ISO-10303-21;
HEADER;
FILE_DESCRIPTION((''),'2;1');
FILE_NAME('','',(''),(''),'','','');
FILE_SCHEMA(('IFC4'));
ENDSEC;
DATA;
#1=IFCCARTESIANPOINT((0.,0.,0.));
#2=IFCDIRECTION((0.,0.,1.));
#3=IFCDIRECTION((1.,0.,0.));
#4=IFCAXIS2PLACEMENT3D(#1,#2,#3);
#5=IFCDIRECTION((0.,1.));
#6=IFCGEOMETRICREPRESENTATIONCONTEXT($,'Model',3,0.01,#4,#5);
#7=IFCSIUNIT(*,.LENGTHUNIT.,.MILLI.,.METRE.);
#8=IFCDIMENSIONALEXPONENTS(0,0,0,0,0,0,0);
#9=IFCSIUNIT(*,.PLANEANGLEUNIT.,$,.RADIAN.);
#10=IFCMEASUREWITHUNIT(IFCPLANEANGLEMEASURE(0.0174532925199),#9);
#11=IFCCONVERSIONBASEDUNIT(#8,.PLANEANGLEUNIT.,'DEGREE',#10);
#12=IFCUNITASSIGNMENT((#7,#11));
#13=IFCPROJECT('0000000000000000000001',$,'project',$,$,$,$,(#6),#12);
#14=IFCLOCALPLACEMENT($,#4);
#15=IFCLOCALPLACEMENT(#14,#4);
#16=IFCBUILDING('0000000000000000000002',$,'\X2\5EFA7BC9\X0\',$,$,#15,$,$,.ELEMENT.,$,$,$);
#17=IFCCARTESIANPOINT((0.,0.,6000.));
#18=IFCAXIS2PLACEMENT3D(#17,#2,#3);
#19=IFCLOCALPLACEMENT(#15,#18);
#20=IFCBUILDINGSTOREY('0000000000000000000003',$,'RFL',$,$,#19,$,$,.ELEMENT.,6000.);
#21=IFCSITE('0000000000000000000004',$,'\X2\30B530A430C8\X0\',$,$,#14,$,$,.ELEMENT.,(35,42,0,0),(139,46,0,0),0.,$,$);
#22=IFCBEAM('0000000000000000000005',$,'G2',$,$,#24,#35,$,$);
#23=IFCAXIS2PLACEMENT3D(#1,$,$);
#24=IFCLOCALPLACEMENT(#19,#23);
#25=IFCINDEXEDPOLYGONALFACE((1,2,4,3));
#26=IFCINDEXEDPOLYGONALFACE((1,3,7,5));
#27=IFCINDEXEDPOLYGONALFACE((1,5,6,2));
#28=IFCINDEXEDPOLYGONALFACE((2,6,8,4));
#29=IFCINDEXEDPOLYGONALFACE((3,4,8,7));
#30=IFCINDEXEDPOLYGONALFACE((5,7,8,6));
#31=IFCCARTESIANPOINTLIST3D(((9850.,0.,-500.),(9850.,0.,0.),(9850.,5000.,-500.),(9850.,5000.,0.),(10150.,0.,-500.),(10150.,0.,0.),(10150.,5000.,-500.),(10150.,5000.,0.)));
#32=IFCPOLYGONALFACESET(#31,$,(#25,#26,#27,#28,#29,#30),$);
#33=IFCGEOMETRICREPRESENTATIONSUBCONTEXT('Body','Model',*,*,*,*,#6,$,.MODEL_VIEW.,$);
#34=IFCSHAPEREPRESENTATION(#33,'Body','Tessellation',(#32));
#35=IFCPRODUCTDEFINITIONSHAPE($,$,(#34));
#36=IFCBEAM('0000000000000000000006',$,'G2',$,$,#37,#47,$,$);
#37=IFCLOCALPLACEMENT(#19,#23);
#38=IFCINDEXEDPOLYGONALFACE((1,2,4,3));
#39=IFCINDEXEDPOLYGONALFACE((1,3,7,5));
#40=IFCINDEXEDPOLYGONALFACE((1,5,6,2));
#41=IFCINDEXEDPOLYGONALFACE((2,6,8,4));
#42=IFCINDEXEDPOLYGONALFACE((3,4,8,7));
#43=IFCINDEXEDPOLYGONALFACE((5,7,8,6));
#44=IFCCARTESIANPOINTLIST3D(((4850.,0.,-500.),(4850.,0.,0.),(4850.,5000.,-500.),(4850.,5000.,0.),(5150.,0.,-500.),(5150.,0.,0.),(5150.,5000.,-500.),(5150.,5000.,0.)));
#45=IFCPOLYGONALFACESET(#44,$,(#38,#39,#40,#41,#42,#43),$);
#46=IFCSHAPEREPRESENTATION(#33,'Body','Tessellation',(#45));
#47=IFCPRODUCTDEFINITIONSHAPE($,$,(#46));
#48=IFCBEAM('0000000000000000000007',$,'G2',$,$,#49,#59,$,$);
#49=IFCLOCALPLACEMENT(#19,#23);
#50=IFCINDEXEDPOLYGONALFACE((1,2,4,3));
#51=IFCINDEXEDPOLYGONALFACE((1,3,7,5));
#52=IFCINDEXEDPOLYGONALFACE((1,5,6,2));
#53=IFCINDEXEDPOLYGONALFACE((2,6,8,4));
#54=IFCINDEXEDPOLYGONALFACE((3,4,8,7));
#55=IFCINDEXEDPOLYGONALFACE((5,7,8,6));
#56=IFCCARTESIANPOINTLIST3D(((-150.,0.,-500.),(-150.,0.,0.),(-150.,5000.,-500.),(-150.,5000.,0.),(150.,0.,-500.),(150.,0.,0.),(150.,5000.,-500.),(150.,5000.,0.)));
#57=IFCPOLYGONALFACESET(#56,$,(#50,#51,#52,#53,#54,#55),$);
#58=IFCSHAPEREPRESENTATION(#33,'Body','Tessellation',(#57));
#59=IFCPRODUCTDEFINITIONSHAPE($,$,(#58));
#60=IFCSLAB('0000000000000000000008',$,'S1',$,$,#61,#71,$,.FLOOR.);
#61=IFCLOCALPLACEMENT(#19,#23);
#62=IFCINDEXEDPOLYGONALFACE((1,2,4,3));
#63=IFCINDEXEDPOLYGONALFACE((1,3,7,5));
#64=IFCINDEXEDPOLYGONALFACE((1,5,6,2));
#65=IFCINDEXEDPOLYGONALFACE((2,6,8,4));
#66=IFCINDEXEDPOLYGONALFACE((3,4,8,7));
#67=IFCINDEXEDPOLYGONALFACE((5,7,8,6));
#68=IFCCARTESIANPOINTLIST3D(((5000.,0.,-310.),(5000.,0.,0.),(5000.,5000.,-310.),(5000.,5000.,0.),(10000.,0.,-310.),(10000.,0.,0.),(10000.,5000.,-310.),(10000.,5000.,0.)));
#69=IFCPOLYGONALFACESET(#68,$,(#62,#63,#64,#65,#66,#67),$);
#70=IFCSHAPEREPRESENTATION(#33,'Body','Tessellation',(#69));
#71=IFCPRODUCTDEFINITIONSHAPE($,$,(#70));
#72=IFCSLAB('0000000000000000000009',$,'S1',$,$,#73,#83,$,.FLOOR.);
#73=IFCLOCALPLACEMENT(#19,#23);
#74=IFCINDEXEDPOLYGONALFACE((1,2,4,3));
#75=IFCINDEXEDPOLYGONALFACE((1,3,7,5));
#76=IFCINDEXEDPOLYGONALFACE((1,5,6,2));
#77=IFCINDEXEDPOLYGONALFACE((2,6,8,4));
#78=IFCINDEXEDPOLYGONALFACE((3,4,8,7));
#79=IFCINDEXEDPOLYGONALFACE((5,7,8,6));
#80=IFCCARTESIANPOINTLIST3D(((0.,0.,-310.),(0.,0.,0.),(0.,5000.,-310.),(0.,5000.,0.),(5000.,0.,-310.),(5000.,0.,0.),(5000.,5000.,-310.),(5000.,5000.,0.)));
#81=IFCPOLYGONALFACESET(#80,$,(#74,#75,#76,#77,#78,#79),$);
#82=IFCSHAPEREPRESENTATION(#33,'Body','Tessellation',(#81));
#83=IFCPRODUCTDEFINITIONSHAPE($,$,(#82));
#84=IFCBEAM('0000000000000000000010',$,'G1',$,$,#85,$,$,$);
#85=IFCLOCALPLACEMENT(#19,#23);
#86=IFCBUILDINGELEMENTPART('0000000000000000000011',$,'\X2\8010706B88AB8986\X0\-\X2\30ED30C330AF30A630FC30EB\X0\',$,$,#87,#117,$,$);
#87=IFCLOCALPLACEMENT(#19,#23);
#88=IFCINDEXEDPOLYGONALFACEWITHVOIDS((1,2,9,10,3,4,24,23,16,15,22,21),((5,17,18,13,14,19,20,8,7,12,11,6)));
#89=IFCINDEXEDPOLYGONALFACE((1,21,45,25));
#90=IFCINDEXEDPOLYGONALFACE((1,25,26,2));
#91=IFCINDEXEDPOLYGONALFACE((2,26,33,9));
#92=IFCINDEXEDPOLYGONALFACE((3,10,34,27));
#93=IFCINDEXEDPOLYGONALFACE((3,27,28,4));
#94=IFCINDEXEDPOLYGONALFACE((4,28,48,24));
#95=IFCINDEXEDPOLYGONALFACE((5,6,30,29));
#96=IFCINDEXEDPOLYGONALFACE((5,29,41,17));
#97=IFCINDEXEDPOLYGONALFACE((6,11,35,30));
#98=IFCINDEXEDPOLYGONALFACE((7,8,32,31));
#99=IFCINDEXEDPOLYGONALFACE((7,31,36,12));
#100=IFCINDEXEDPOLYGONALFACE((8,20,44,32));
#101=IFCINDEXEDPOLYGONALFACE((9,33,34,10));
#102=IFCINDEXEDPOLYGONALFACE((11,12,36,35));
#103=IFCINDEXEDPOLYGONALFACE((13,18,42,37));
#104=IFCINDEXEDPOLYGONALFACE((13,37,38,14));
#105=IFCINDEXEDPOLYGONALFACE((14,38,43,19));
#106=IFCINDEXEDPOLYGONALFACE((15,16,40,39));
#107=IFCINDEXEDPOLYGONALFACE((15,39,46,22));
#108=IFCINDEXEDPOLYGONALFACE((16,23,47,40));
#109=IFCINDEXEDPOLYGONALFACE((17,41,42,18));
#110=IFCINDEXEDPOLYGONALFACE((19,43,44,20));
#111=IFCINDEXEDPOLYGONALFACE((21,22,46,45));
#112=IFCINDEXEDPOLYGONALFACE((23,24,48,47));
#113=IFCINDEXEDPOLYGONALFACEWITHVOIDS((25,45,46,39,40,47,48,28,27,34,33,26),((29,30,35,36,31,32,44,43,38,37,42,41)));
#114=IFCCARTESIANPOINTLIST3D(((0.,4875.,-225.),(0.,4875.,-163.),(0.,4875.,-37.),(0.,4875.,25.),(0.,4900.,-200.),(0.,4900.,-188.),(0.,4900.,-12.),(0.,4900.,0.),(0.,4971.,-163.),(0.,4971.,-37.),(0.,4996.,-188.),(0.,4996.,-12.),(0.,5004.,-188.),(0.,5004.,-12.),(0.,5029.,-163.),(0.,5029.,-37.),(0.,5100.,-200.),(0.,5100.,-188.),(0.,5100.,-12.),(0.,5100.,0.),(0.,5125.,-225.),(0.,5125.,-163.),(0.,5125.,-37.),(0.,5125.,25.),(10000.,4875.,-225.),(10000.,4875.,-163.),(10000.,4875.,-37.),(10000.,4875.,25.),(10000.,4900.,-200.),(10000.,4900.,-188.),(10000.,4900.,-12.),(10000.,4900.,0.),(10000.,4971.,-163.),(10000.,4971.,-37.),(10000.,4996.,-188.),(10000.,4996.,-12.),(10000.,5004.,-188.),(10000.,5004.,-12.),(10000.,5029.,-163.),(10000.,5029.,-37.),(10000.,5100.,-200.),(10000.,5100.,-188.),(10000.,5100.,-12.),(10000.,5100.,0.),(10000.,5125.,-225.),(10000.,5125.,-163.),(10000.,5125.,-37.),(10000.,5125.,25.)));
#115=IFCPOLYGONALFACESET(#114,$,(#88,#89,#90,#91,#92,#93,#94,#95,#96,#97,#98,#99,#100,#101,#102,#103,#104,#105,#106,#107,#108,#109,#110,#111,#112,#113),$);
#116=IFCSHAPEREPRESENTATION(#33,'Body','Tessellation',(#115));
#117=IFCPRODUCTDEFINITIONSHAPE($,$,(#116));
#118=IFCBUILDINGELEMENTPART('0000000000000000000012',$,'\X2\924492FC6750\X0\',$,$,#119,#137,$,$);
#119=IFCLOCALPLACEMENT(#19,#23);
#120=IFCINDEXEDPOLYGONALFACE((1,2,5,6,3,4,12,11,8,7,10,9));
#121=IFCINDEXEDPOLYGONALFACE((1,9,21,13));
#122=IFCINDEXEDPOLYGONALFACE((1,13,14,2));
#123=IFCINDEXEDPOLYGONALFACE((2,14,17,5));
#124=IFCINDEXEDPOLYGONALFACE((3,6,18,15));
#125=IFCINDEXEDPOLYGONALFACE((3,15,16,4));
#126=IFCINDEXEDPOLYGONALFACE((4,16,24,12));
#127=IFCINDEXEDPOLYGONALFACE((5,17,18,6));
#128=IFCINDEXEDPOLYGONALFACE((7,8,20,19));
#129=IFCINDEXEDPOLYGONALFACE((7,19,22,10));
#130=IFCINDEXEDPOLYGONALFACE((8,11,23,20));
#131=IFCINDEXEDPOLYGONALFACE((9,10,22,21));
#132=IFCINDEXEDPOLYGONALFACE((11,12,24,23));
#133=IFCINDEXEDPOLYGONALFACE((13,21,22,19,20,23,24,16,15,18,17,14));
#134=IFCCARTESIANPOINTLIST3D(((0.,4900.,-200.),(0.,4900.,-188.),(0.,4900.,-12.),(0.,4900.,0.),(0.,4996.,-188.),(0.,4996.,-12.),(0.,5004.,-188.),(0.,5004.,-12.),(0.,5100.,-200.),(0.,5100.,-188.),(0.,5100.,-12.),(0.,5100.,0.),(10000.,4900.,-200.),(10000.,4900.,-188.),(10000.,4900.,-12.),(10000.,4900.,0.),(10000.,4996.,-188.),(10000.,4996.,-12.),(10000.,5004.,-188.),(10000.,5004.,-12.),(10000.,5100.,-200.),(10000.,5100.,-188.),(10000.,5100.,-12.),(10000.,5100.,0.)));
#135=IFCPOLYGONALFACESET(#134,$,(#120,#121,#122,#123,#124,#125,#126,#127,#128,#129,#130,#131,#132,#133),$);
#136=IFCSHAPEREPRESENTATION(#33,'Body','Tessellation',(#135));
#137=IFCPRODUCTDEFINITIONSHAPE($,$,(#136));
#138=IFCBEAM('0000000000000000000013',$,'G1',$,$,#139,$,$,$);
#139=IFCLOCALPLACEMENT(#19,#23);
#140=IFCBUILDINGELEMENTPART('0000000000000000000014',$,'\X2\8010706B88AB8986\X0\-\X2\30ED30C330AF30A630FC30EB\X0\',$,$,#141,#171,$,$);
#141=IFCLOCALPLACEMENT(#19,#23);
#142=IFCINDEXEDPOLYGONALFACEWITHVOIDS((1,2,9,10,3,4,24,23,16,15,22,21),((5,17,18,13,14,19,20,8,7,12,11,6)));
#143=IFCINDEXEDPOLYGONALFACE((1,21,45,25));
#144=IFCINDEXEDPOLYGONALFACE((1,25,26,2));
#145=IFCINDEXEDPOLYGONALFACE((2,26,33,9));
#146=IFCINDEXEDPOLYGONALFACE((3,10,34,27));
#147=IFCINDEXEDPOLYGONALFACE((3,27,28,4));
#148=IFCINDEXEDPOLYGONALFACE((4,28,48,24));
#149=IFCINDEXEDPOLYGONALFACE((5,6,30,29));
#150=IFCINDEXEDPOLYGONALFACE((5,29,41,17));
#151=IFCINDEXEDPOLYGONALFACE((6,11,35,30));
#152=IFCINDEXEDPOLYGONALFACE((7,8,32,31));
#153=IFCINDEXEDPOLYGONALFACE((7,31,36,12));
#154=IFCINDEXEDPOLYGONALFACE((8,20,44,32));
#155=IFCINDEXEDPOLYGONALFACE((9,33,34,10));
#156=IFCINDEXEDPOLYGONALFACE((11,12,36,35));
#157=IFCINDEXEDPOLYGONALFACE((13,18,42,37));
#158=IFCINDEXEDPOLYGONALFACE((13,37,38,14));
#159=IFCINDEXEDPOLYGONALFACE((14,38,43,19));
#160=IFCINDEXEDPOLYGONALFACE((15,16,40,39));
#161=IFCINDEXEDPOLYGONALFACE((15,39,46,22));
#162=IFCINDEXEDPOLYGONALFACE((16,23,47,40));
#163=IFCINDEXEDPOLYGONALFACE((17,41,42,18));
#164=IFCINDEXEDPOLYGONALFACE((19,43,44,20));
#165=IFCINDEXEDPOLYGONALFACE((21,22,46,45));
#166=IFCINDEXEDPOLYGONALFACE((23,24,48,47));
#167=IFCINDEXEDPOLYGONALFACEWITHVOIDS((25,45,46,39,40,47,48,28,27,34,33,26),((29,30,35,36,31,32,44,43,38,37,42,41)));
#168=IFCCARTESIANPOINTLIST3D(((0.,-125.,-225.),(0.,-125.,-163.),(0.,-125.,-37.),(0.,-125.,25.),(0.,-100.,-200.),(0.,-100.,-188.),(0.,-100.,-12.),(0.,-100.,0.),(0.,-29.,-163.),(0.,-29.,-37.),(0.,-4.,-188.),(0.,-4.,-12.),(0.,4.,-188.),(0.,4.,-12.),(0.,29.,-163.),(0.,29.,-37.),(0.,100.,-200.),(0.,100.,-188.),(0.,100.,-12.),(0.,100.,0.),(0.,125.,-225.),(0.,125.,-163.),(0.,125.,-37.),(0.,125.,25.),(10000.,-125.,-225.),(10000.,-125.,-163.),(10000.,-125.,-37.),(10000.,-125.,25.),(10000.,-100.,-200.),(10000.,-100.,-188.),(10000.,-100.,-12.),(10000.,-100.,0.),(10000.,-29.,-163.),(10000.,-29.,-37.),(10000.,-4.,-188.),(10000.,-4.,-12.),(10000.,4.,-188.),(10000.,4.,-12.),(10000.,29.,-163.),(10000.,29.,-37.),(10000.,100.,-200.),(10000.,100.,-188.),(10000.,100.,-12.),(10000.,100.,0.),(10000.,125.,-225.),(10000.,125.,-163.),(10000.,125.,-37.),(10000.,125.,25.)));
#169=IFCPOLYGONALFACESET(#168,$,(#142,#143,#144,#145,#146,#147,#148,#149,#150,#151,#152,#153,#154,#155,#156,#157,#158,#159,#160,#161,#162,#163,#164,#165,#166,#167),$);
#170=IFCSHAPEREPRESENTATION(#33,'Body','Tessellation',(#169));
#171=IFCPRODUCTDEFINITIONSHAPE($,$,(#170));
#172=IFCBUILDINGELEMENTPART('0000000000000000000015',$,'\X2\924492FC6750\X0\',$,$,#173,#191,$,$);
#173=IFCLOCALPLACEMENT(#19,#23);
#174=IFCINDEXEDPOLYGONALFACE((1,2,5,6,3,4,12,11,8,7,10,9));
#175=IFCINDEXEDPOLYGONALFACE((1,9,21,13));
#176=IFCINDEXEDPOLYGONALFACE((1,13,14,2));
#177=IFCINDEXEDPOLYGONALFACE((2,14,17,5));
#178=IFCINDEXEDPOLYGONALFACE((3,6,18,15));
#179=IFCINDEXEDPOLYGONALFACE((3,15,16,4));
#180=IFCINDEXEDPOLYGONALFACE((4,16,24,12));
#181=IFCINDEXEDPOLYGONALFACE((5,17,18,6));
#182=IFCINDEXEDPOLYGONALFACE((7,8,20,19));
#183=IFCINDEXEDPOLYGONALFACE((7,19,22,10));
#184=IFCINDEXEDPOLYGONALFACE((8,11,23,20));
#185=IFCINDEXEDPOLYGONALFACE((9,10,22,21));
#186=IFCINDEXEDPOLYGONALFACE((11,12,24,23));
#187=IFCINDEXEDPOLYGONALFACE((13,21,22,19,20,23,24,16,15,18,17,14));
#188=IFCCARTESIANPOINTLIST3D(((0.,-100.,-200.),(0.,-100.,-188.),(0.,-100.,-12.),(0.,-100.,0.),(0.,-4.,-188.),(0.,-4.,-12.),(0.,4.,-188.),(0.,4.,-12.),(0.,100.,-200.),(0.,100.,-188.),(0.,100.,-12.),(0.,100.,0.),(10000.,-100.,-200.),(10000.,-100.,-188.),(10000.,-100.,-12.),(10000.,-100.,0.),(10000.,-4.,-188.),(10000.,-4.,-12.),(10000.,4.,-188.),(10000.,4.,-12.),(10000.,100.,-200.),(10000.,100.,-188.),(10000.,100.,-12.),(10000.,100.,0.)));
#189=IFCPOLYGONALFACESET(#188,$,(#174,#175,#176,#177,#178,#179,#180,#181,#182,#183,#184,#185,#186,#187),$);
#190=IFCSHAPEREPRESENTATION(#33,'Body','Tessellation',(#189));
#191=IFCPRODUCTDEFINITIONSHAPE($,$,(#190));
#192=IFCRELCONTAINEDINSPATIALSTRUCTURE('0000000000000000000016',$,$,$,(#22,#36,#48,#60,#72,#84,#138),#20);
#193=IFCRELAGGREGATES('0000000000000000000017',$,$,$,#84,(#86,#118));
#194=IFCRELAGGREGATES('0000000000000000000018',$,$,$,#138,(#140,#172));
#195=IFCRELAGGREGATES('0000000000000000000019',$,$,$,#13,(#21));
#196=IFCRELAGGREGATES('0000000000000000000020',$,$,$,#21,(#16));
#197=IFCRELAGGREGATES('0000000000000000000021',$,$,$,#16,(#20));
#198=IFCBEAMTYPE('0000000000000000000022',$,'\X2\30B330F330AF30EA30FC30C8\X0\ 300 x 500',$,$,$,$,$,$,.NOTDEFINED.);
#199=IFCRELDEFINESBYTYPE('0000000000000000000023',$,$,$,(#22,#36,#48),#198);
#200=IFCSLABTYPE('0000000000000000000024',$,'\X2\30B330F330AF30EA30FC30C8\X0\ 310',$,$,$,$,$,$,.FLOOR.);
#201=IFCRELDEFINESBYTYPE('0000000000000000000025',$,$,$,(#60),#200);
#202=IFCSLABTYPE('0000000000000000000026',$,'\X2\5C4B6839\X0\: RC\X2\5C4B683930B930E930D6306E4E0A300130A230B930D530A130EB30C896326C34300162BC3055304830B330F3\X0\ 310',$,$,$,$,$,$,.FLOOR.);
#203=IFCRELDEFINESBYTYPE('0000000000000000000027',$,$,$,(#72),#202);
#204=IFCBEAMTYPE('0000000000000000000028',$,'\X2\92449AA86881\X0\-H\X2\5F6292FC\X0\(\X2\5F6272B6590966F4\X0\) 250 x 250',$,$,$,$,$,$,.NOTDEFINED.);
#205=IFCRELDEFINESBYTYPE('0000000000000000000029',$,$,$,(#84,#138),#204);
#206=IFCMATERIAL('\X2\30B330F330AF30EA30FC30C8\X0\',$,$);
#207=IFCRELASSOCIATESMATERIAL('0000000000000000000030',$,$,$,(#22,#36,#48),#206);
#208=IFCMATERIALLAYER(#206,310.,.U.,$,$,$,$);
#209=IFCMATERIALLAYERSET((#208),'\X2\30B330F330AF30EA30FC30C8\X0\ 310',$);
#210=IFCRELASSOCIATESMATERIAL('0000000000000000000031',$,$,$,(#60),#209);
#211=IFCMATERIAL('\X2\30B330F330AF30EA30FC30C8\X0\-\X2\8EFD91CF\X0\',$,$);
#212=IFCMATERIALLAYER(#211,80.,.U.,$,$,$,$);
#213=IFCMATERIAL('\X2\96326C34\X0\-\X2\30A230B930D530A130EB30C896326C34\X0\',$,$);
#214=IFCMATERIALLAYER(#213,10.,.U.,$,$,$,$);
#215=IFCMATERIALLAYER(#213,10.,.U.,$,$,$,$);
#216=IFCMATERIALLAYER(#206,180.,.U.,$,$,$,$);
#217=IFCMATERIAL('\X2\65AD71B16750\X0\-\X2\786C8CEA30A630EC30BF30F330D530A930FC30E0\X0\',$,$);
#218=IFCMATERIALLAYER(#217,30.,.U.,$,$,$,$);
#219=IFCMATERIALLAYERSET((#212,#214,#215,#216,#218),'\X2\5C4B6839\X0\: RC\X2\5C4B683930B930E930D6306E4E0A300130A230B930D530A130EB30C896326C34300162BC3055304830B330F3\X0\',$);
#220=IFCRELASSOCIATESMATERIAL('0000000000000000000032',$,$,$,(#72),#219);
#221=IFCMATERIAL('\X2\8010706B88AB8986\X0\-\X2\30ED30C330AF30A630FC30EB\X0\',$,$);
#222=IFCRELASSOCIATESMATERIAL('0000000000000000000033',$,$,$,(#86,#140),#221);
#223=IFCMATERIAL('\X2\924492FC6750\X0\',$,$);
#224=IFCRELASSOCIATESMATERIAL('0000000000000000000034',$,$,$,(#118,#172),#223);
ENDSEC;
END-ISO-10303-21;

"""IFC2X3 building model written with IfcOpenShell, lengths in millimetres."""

from ifc_helpers import new_model, entity, si_unit, converted_unit, direction, frame, frame_2d, origin_with_axes, place, context, subcontext, project, spatial, polyline, rectangle, outline, extrude, material, layer, layer_set, layer_usage, type_object, element, aggregate, save


model = new_model("IFC2X3")

# Units and contexts
model_context = context("Model", 3, precision=0.01, world=origin_with_axes(), true_north=direction((0.0, 1.0)))
body_context = subcontext(model_context, "Body", "Model", "MODEL_VIEW")
ifc_project = project(units=[si_unit("LENGTHUNIT", "METRE", prefix="MILLI"), converted_unit("PLANEANGLEUNIT", "DEGREE", entity("IfcPlaneAngleMeasure", 0.0174532925199), si_unit("PLANEANGLEUNIT", "RADIAN"), dimensions=[0, 0, 0, 0, 0, 0, 0])], contexts=[model_context])

# Site, building, storey
site_placement = place(None, origin_with_axes())
site = spatial("IfcSite", under=ifc_project, at=site_placement, Name="サイト", CompositionType="ELEMENT", RefLatitude=(35, 42, 0, 0), RefLongitude=(139, 46, 0, 0), RefElevation=0.0)
building_placement = place(site_placement, origin_with_axes())
building = spatial("IfcBuilding", under=site, at=building_placement, Name="建築", CompositionType="ELEMENT")
storey_placement = place(building_placement, frame((0.0, 0.0, 6000.0), z_axis=(0.0, 0.0, 1.0), x_axis=(1.0, 0.0, 0.0)))
storey = spatial("IfcBuildingStorey", under=building, at=storey_placement, Name="RFL", CompositionType="ELEMENT", Elevation=6000.0)

# Beams
ifc_material_1 = material(Name="コンクリート")
beam_type_1 = type_object("IfcBeamType", Name="コンクリート 300 x 500", PredefinedType="NOTDEFINED")
for number, where, z_axis, x_axis, name in (
    (1, (10000.0, 5000.0, 0.0), (0.0, 0.0, 1.0), (-1.0, 0.0, 0.0), "G2"),
    (2, (5000.0, 5000.0, 0.0), (0.0, 0.0, 1.0), (-1.0, 0.0, 0.0), "G2"),
    (3, (0.0, 5000.0, 0.0), (0.0, 0.0, 1.0), (-1.0, 0.0, 0.0), "G2"),
):
    element("IfcBeam", number, at=place(storey_placement, frame(where, z_axis=z_axis, x_axis=x_axis)), inside=storey, type_object=beam_type_1, material=ifc_material_1, Name=name, context=body_context, shape_type="SweptSolid", body=[
        extrude(rectangle(XDim=500.0, YDim=300.0, at=frame_2d((-250.0, 0.0), x_axis=(1.0, 0.0))), frame((0.0, 0.0, 0.0), z_axis=(0.0, 1.0, 0.0), x_axis=(0.0, 0.0, 1.0)), (0.0, 0.0, 1.0), 5000.0),
    ])

# Slabs
ifc_layer_1 = layer(ifc_material_1, 310.0, ventilated="UNKNOWN")
ifc_layer_set_1 = layer_set([ifc_layer_1], Name="コンクリート 310")
ifc_layer_usage_1 = layer_usage(ifc_layer_set_1, "AXIS3", "NEGATIVE", 310.0)
slab_type_1 = type_object("IfcSlabType", Name="コンクリート 310", PredefinedType="FLOOR")
slab_1_placement = place(storey_placement, frame((5000.0, 0.0, 0.0), z_axis=(0.0, 0.0, 1.0), x_axis=(1.0, 0.0, 0.0)))
element("IfcSlab", 4, at=slab_1_placement, inside=storey, type_object=slab_type_1, material=ifc_layer_usage_1, Name="S1", PredefinedType="FLOOR", context=body_context, shape_type="SweptSolid", body=[
    extrude(outline(polyline([(0.0, 0.0), (5000.0, 0.0), (5000.0, 5000.0), (0.0, 5000.0), (0.0, 0.0)])), frame((0.0, 0.0, -310.0), z_axis=(0.0, 0.0, 1.0), x_axis=(1.0, 0.0, 0.0)), (0.0, 0.0, 1.0), 310.0),
])
ifc_material_2 = material(Name="コンクリート-軽量")
ifc_layer_2 = layer(ifc_material_2, 80.0, ventilated="UNKNOWN")
ifc_material_3 = material(Name="防水-アスファルト防水")
ifc_layer_3 = layer(ifc_material_3, 10.0, ventilated="UNKNOWN")
ifc_layer_4 = layer(ifc_material_3, 10.0, ventilated="UNKNOWN")
ifc_layer_5 = layer(ifc_material_1, 180.0, ventilated="UNKNOWN")
ifc_material_4 = material(Name="断熱材-硬質ウレタンフォーム")
ifc_layer_6 = layer(ifc_material_4, 30.0, ventilated="UNKNOWN")
ifc_layer_set_2 = layer_set([ifc_layer_2, ifc_layer_3, ifc_layer_4, ifc_layer_5, ifc_layer_6], Name="屋根: RC屋根スラブの上、アスファルト防水、押さえコン")
ifc_layer_usage_2 = layer_usage(ifc_layer_set_2, "AXIS3", "NEGATIVE", 310.0)
slab_type_2 = type_object("IfcSlabType", Name="屋根: RC屋根スラブの上、アスファルト防水、押さえコン 310", PredefinedType="FLOOR")
slab_2_placement = place(storey_placement, origin_with_axes())
element("IfcSlab", 5, at=slab_2_placement, inside=storey, type_object=slab_type_2, material=ifc_layer_usage_2, Name="S1", PredefinedType="FLOOR", context=body_context, shape_type="SweptSolid", body=[
    extrude(outline(polyline([(0.0, 0.0), (5000.0, 0.0), (5000.0, 5000.0), (0.0, 5000.0), (0.0, 0.0)])), frame((0.0, 0.0, -310.0), z_axis=(0.0, 0.0, 1.0), x_axis=(1.0, 0.0, 0.0)), (0.0, 0.0, 1.0), 310.0),
])

# Beams, building element parts
beam_type_2 = type_object("IfcBeamType", Name="鉄骨梁-H形鋼(形状変更) 250 x 250", PredefinedType="NOTDEFINED")
beam_1_placement = place(storey_placement, frame((0.0, 5000.0, 0.0), z_axis=(0.0, 0.0, 1.0), x_axis=(0.0, -1.0, 0.0)))
beam_1 = element("IfcBeam", 6, at=beam_1_placement, inside=storey, type_object=beam_type_2, Name="G1")
ifc_material_5 = material(Name="耐火被覆-ロックウール")
building_element_part_1_placement = place(beam_1_placement, origin_with_axes())
building_element_part_1 = element("IfcBuildingElementPart", 7, at=building_element_part_1_placement, material=ifc_material_5, Name="耐火被覆-ロックウール", context=body_context, shape_type="SweptSolid", body=[
    extrude(outline(polyline([(-125.0, 25.0), (-125.0, -37.0), (-29.0, -37.0), (-29.0, -163.0), (-125.0, -163.0), (-125.0, -225.0), (125.0, -225.0), (125.0, -163.0), (29.0, -163.0), (29.0, -37.0), (125.0, -37.0), (125.0, 25.0), (-125.0, 25.0)]), holes=[polyline([(-100.0, -188.0), (-4.0, -188.0), (-4.0, -12.0), (-100.0, -12.0), (-100.0, 0.0), (100.0, 0.0), (100.0, -12.0), (4.0, -12.0), (4.0, -188.0), (100.0, -188.0), (100.0, -200.0), (-100.0, -200.0), (-100.0, -188.0)])]), frame((0.0, 10000.0, 0.0), z_axis=(0.0, -1.0, 0.0), x_axis=(1.0, 0.0, 0.0)), (0.0, 0.0, 1.0), 10000.0),
])
ifc_material_6 = material(Name="鉄鋼材")
building_element_part_2_placement = place(beam_1_placement, origin_with_axes())
building_element_part_2 = element("IfcBuildingElementPart", 8, at=building_element_part_2_placement, material=ifc_material_6, Name="鉄鋼材", context=body_context, shape_type="SweptSolid", body=[
    extrude(outline(polyline([(-100.0, 0.0), (-100.0, -12.0), (-4.0, -12.0), (-4.0, -188.0), (-100.0, -188.0), (-100.0, -200.0), (100.0, -200.0), (100.0, -188.0), (4.0, -188.0), (4.0, -12.0), (100.0, -12.0), (100.0, 0.0), (-100.0, 0.0)])), frame((0.0, 10000.0, 0.0), z_axis=(0.0, -1.0, 0.0), x_axis=(1.0, 0.0, 0.0)), (0.0, 0.0, 1.0), 10000.0),
])
aggregate(beam_1, [building_element_part_1, building_element_part_2])
beam_2_placement = place(storey_placement, frame((0.0, 0.0, 0.0), z_axis=(0.0, 0.0, 1.0), x_axis=(0.0, -1.0, 0.0)))
beam_2 = element("IfcBeam", 9, at=beam_2_placement, inside=storey, type_object=beam_type_2, Name="G1")
building_element_part_3_placement = place(beam_2_placement, origin_with_axes())
building_element_part_3 = element("IfcBuildingElementPart", 10, at=building_element_part_3_placement, material=ifc_material_5, Name="耐火被覆-ロックウール", context=body_context, shape_type="SweptSolid", body=[
    extrude(outline(polyline([(-125.0, 25.0), (-125.0, -37.0), (-29.0, -37.0), (-29.0, -163.0), (-125.0, -163.0), (-125.0, -225.0), (125.0, -225.0), (125.0, -163.0), (29.0, -163.0), (29.0, -37.0), (125.0, -37.0), (125.0, 25.0), (-125.0, 25.0)]), holes=[polyline([(-100.0, -188.0), (-4.0, -188.0), (-4.0, -12.0), (-100.0, -12.0), (-100.0, 0.0), (100.0, 0.0), (100.0, -12.0), (4.0, -12.0), (4.0, -188.0), (100.0, -188.0), (100.0, -200.0), (-100.0, -200.0), (-100.0, -188.0)])]), frame((0.0, 10000.0, 0.0), z_axis=(0.0, -1.0, 0.0), x_axis=(1.0, 0.0, 0.0)), (0.0, 0.0, 1.0), 10000.0),
])
building_element_part_4_placement = place(beam_2_placement, origin_with_axes())
building_element_part_4 = element("IfcBuildingElementPart", 11, at=building_element_part_4_placement, material=ifc_material_6, Name="鉄鋼材", context=body_context, shape_type="SweptSolid", body=[
    extrude(outline(polyline([(-100.0, 0.0), (-100.0, -12.0), (-4.0, -12.0), (-4.0, -188.0), (-100.0, -188.0), (-100.0, -200.0), (100.0, -200.0), (100.0, -188.0), (4.0, -188.0), (4.0, -12.0), (100.0, -12.0), (100.0, 0.0), (-100.0, 0.0)])), frame((0.0, 10000.0, 0.0), z_axis=(0.0, -1.0, 0.0), x_axis=(1.0, 0.0, 0.0)), (0.0, 0.0, 1.0), 10000.0),
])
aggregate(beam_2, [building_element_part_3, building_element_part_4])

save(model, "model.ifc")
